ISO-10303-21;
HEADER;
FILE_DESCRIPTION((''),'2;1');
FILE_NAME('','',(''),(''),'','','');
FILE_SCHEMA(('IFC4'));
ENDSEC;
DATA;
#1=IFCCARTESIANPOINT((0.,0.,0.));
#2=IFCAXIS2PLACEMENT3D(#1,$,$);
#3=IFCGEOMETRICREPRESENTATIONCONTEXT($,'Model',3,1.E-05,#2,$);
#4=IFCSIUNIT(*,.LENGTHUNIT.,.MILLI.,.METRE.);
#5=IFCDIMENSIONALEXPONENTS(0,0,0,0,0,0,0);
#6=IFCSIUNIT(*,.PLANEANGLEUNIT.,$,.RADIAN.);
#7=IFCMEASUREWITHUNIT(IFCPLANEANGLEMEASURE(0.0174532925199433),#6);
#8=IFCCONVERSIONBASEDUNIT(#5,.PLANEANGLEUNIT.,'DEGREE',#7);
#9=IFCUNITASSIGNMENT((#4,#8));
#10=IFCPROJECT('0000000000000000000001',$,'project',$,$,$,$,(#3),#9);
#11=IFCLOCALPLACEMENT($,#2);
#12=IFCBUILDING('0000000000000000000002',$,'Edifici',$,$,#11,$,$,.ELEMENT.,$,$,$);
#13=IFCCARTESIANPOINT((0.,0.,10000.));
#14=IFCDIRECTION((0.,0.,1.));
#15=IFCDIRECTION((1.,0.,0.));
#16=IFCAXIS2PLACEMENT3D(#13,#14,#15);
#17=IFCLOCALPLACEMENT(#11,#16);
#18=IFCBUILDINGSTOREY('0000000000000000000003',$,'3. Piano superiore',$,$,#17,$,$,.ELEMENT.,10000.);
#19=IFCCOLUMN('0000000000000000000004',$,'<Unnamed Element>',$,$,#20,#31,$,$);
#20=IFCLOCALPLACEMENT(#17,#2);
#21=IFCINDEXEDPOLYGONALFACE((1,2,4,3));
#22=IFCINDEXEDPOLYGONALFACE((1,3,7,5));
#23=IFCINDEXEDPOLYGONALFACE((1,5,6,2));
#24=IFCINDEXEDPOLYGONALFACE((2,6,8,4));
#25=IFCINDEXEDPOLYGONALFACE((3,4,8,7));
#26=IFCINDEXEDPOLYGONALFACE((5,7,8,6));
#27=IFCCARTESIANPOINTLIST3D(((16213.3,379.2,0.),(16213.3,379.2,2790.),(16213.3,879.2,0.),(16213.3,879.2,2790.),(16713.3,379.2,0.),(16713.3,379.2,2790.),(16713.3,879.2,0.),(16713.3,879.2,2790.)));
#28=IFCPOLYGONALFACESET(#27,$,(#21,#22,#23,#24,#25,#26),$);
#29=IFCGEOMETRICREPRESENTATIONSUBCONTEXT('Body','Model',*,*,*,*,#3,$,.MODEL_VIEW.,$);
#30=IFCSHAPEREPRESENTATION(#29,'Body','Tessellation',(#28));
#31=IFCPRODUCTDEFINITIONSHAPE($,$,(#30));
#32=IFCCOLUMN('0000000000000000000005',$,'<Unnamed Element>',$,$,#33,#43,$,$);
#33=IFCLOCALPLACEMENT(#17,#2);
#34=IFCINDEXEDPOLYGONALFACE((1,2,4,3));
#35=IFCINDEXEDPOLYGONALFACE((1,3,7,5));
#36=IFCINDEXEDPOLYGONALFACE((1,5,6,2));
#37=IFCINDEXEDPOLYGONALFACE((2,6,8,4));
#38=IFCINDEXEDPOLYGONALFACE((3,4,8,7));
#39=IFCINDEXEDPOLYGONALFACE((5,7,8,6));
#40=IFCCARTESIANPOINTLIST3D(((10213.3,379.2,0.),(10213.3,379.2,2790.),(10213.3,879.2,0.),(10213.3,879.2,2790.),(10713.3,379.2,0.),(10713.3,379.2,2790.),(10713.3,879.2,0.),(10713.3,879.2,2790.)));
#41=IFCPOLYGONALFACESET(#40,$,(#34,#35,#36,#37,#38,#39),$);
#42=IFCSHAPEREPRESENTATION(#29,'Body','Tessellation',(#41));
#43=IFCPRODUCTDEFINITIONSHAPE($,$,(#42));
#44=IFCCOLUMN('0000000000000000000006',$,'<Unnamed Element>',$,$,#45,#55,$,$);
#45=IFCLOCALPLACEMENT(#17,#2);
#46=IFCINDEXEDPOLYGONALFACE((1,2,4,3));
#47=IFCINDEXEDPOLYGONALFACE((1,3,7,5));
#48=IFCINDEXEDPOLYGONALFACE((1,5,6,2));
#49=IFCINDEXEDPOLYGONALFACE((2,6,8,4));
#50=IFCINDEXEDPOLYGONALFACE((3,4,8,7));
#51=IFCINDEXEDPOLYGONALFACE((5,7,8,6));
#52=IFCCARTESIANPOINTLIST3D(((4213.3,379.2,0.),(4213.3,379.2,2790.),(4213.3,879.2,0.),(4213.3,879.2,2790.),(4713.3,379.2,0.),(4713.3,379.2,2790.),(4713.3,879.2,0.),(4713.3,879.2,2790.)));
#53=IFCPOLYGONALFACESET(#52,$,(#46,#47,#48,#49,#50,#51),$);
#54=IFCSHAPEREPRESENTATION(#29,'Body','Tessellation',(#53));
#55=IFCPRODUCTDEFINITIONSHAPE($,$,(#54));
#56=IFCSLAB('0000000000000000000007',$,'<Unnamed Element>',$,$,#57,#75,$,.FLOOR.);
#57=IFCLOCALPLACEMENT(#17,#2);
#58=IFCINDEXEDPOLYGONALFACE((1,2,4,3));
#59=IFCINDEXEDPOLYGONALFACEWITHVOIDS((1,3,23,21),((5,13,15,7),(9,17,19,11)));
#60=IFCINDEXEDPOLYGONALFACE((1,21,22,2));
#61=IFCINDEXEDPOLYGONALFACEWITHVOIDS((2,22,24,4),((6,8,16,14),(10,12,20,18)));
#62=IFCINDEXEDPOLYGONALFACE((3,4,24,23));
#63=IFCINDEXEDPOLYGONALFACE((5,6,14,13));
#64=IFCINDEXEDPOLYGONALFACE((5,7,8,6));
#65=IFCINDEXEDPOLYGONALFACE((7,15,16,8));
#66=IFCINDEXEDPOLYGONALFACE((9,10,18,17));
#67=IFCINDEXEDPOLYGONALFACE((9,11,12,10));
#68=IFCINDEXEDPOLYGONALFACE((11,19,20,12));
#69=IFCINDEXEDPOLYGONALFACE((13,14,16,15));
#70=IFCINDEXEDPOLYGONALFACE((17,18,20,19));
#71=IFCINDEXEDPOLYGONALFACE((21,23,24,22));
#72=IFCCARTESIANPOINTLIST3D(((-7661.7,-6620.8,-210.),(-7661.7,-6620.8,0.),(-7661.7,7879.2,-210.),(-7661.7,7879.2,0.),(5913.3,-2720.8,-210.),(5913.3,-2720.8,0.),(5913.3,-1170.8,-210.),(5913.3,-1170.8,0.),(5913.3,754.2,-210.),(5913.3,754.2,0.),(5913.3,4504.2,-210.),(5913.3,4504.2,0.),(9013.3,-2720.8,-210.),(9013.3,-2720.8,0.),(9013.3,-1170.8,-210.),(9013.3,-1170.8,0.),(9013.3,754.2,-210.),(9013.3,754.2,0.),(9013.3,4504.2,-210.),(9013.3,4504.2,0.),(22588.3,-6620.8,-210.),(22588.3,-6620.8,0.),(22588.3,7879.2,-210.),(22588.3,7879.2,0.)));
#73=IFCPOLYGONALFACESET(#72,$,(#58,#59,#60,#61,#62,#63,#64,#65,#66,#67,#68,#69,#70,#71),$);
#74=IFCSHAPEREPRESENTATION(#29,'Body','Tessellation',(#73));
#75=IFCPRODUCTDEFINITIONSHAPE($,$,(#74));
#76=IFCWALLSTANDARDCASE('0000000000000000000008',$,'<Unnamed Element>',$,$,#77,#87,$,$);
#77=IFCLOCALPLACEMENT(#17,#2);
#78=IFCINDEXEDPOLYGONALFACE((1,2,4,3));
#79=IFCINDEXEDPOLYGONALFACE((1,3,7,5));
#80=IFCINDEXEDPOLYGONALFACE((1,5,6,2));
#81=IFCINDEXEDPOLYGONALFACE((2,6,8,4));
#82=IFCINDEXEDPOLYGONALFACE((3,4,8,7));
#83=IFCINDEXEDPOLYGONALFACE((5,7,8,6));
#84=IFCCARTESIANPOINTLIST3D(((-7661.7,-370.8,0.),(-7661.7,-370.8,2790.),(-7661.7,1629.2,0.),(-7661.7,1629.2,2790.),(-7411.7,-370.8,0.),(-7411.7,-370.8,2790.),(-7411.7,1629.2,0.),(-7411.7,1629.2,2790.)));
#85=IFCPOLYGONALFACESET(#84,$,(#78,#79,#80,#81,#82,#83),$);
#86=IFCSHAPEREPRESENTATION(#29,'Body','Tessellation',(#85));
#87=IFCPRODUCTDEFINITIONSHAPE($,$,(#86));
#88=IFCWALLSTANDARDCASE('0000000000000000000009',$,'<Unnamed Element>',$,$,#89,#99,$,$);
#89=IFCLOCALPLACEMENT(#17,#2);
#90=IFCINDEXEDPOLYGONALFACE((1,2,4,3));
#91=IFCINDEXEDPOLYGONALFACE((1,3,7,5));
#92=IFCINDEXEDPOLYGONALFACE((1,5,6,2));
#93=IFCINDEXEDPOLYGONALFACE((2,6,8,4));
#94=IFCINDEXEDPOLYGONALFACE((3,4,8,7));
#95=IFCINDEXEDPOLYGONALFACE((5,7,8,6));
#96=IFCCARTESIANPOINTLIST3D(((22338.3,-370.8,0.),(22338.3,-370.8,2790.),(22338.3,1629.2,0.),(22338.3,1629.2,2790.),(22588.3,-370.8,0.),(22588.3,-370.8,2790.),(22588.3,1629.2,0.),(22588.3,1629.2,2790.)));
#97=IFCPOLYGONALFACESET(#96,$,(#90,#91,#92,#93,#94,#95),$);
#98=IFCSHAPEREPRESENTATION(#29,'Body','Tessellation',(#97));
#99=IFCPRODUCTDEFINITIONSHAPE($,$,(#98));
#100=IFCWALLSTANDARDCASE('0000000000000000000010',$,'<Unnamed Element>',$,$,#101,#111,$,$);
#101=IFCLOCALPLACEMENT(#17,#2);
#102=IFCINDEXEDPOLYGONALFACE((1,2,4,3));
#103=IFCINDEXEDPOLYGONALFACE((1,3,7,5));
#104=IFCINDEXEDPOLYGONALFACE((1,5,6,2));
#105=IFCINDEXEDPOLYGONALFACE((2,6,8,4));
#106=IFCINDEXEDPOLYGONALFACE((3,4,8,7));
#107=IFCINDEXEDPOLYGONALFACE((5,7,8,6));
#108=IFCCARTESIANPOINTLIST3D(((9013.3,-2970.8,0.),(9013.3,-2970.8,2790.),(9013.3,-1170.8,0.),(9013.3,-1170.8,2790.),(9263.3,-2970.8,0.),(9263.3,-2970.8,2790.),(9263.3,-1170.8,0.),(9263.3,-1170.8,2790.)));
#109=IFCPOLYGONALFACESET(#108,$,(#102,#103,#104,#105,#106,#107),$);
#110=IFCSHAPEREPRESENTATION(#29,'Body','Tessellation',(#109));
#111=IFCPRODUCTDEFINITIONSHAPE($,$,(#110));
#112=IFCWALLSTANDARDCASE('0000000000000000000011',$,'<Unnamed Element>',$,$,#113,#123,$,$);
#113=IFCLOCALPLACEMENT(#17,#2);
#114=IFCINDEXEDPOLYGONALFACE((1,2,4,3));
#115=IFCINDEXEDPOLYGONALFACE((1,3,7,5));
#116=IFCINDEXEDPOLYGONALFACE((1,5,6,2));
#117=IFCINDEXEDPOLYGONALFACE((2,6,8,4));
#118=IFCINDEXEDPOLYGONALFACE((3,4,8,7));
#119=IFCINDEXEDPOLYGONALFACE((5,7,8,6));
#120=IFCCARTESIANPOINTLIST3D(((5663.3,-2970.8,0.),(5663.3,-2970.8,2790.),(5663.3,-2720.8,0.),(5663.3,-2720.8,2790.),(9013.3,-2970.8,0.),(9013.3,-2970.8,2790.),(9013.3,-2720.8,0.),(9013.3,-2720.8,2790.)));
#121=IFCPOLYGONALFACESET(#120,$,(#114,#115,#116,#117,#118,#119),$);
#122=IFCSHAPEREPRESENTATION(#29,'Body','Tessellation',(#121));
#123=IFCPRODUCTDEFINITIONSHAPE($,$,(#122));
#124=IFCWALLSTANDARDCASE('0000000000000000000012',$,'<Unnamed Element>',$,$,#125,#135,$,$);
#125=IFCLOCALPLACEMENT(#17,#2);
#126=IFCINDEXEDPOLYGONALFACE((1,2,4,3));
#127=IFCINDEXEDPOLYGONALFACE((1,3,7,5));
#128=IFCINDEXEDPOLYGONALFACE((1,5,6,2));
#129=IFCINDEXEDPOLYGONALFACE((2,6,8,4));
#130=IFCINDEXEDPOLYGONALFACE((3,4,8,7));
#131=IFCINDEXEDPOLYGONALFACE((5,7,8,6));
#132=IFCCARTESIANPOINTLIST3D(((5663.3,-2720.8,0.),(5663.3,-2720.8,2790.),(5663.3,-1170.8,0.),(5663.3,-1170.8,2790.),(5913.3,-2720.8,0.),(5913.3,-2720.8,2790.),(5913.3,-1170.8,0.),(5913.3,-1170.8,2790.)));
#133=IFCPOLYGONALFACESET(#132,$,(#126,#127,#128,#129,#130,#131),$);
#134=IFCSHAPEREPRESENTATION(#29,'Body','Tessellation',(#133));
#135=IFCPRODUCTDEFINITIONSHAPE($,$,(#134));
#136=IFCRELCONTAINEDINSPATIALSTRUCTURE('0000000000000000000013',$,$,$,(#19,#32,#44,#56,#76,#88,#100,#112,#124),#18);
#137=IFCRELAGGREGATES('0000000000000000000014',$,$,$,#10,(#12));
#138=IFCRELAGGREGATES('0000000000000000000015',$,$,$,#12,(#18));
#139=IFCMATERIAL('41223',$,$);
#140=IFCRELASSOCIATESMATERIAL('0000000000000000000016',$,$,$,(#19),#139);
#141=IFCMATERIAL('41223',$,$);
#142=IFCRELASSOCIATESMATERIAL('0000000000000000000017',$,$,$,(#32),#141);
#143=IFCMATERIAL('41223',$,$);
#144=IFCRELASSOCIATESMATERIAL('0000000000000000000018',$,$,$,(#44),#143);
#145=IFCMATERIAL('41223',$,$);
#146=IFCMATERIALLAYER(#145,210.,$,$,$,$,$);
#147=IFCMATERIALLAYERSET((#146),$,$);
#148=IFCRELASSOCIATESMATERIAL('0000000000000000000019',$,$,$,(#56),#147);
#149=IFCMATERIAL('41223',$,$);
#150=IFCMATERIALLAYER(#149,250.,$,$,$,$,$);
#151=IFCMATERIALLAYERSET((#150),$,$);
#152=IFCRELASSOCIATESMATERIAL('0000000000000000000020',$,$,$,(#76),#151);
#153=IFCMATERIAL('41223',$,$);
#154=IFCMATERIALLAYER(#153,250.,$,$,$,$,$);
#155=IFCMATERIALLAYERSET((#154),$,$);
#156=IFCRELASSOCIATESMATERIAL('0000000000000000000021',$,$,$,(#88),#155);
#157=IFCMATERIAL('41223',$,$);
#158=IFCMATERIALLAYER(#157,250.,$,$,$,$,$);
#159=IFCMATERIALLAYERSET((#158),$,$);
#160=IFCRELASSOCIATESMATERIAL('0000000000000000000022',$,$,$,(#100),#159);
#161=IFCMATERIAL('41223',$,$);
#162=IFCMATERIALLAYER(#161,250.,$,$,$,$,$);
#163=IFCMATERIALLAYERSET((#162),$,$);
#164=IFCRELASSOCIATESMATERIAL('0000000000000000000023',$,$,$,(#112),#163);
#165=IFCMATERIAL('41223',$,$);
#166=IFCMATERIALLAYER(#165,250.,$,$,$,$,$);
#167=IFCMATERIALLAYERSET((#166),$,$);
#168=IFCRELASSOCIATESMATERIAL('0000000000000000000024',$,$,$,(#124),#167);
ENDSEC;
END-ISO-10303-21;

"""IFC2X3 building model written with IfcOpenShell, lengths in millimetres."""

from ifc_helpers import new_model, entity, si_unit, converted_unit, frame, frame_2d, origin, origin_with_axes, place, context, subcontext, project, spatial, polyline, rectangle, outline, extrude, material, layer, layer_set, layer_usage, element, save


model = new_model("IFC2X3")

# Units and contexts
model_context = context("Model", 3, precision=1e-05, world=origin())
body_context = subcontext(model_context, "Body", "Model", "MODEL_VIEW")
ifc_project = project(units=[si_unit("LENGTHUNIT", "METRE", prefix="MILLI"), converted_unit("PLANEANGLEUNIT", "DEGREE", entity("IfcPlaneAngleMeasure", 0.0174532925199433), si_unit("PLANEANGLEUNIT", "RADIAN"), dimensions=[0, 0, 0, 0, 0, 0, 0])], contexts=[model_context])

# Building, storey
building_placement = place(None, origin())
building = spatial("IfcBuilding", under=ifc_project, at=building_placement, Name="Edifici", CompositionType="ELEMENT")
storey_placement = place(building_placement, frame((0.0, 0.0, 10000.0), z_axis=(0.0, 0.0, 1.0), x_axis=(1.0, 0.0, 0.0)))
storey = spatial("IfcBuildingStorey", under=building, at=storey_placement, Name="3. Piano superiore", CompositionType="ELEMENT", Elevation=10000.0)

# Columns
ifc_material_1 = material(Name="41223")
column_1_placement = place(storey_placement, frame((16213.3, 379.2, 0.0), z_axis=(0.0, 0.0, 1.0), x_axis=(1.0, 0.0, 0.0)))
element("IfcColumn", 1, at=column_1_placement, inside=storey, material=ifc_material_1, Name="<Unnamed Element>", context=body_context, shape_type="SweptSolid", body=[
    extrude(rectangle(XDim=500.0, YDim=500.0, at=frame_2d((250.0, 250.0), x_axis=(1.0, 0.0))), origin_with_axes(), (0.0, 0.0, 1.0), 2790.0),
])
ifc_material_2 = material(Name="41223")
column_2_placement = place(storey_placement, frame((10213.3, 379.2, 0.0), z_axis=(0.0, 0.0, 1.0), x_axis=(1.0, 0.0, 0.0)))
element("IfcColumn", 2, at=column_2_placement, inside=storey, material=ifc_material_2, Name="<Unnamed Element>", context=body_context, shape_type="SweptSolid", body=[
    extrude(rectangle(XDim=500.0, YDim=500.0, at=frame_2d((250.0, 250.0), x_axis=(1.0, 0.0))), origin_with_axes(), (0.0, 0.0, 1.0), 2790.0),
])
ifc_material_3 = material(Name="41223")
column_3_placement = place(storey_placement, frame((4213.3, 379.2, 0.0), z_axis=(0.0, 0.0, 1.0), x_axis=(1.0, 0.0, 0.0)))
element("IfcColumn", 3, at=column_3_placement, inside=storey, material=ifc_material_3, Name="<Unnamed Element>", context=body_context, shape_type="SweptSolid", body=[
    extrude(rectangle(XDim=500.0, YDim=500.0, at=frame_2d((250.0, 250.0), x_axis=(1.0, 0.0))), origin_with_axes(), (0.0, 0.0, 1.0), 2790.0),
])

# Slab
ifc_material_4 = material(Name="41223")
ifc_layer_1 = layer(ifc_material_4, 210.0)
ifc_layer_set_1 = layer_set([ifc_layer_1])
ifc_layer_usage_1 = layer_usage(ifc_layer_set_1, "AXIS3", "POSITIVE", 0.0)
slab_placement = place(storey_placement, frame((-7661.7, -6620.8, -210.0), z_axis=(0.0, 0.0, 1.0), x_axis=(1.0, 0.0, 0.0)))
element("IfcSlab", 4, at=slab_placement, inside=storey, material=ifc_layer_usage_1, Name="<Unnamed Element>", PredefinedType="FLOOR", context=body_context, shape_type="SweptSolid", body=[
    extrude(outline(polyline([(0.0, 0.0), (30250.0, 0.0), (30250.0, 14500.0), (0.0, 14500.0), (0.0, 0.0)]), holes=[polyline([(13575.0, 11125.0), (16675.0, 11125.0), (16675.0, 7375.0), (13575.0, 7375.0), (13575.0, 11125.0)]), polyline([(16675.0, 3900.0), (13575.0, 3900.0), (13575.0, 5450.0), (16675.0, 5450.0), (16675.0, 3900.0)])]), origin_with_axes(), (0.0, 0.0, 1.0), 210.0),
])

# Walls
ifc_material_5 = material(Name="41223")
ifc_layer_2 = layer(ifc_material_5, 250.0)
ifc_layer_set_2 = layer_set([ifc_layer_2])
ifc_layer_usage_2 = layer_usage(ifc_layer_set_2, "AXIS2", "POSITIVE", 0.0)
wall_1_placement = place(storey_placement, frame((-7661.7, 1629.2, 0.0), z_axis=(0.0, 0.0, 1.0), x_axis=(0.0, -1.0, 0.0)))
element("IfcWallStandardCase", 5, at=wall_1_placement, inside=storey, material=ifc_layer_usage_2, Name="<Unnamed Element>", context=body_context, shape_type="SweptSolid", body=[
    extrude(rectangle(XDim=2000.0, YDim=250.0, at=frame_2d((1000.0, 125.0), x_axis=(1.0, 0.0))), origin_with_axes(), (0.0, 0.0, 1.0), 2790.0),
])
ifc_material_6 = material(Name="41223")
ifc_layer_3 = layer(ifc_material_6, 250.0)
ifc_layer_set_3 = layer_set([ifc_layer_3])
ifc_layer_usage_3 = layer_usage(ifc_layer_set_3, "AXIS2", "POSITIVE", 0.0)
wall_2_placement = place(storey_placement, frame((22338.3, 1629.2, 0.0), z_axis=(0.0, 0.0, 1.0), x_axis=(0.0, -1.0, 0.0)))
element("IfcWallStandardCase", 6, at=wall_2_placement, inside=storey, material=ifc_layer_usage_3, Name="<Unnamed Element>", context=body_context, shape_type="SweptSolid", body=[
    extrude(rectangle(XDim=2000.0, YDim=250.0, at=frame_2d((1000.0, 125.0), x_axis=(1.0, 0.0))), origin_with_axes(), (0.0, 0.0, 1.0), 2790.0),
])
ifc_material_7 = material(Name="41223")
ifc_layer_4 = layer(ifc_material_7, 250.0)
ifc_layer_set_4 = layer_set([ifc_layer_4])
ifc_layer_usage_4 = layer_usage(ifc_layer_set_4, "AXIS2", "POSITIVE", 0.0)
wall_3_placement = place(storey_placement, frame((9263.3, -2970.8, 0.0), z_axis=(0.0, 0.0, 1.0), x_axis=(0.0, 1.0, 0.0)))
element("IfcWallStandardCase", 7, at=wall_3_placement, inside=storey, material=ifc_layer_usage_4, Name="<Unnamed Element>", context=body_context, shape_type="SweptSolid", body=[
    extrude(rectangle(XDim=1800.0, YDim=250.0, at=frame_2d((900.0, 125.0), x_axis=(1.0, 0.0))), origin_with_axes(), (0.0, 0.0, 1.0), 2790.0),
])
ifc_material_8 = material(Name="41223")
ifc_layer_5 = layer(ifc_material_8, 250.0)
ifc_layer_set_5 = layer_set([ifc_layer_5])
ifc_layer_usage_5 = layer_usage(ifc_layer_set_5, "AXIS2", "POSITIVE", 0.0)
wall_4_placement = place(storey_placement, frame((5663.3, -2970.8, 0.0), z_axis=(0.0, 0.0, 1.0), x_axis=(1.0, 0.0, 0.0)))
element("IfcWallStandardCase", 8, at=wall_4_placement, inside=storey, material=ifc_layer_usage_5, Name="<Unnamed Element>", context=body_context, shape_type="SweptSolid", body=[
    extrude(rectangle(XDim=3350.0, YDim=250.0, at=frame_2d((1675.0, 125.0), x_axis=(1.0, 0.0))), origin_with_axes(), (0.0, 0.0, 1.0), 2790.0),
])
ifc_material_9 = material(Name="41223")
ifc_layer_6 = layer(ifc_material_9, 250.0)
ifc_layer_set_6 = layer_set([ifc_layer_6])
ifc_layer_usage_6 = layer_usage(ifc_layer_set_6, "AXIS2", "POSITIVE", 0.0)
wall_5_placement = place(storey_placement, frame((5663.3, -1170.8, 0.0), z_axis=(0.0, 0.0, 1.0), x_axis=(0.0, -1.0, 0.0)))
element("IfcWallStandardCase", 9, at=wall_5_placement, inside=storey, material=ifc_layer_usage_6, Name="<Unnamed Element>", context=body_context, shape_type="SweptSolid", body=[
    extrude(rectangle(XDim=1550.0, YDim=250.0, at=frame_2d((775.0, 125.0), x_axis=(1.0, 0.0))), origin_with_axes(), (0.0, 0.0, 1.0), 2790.0),
])

save(model, "model.ifc")
